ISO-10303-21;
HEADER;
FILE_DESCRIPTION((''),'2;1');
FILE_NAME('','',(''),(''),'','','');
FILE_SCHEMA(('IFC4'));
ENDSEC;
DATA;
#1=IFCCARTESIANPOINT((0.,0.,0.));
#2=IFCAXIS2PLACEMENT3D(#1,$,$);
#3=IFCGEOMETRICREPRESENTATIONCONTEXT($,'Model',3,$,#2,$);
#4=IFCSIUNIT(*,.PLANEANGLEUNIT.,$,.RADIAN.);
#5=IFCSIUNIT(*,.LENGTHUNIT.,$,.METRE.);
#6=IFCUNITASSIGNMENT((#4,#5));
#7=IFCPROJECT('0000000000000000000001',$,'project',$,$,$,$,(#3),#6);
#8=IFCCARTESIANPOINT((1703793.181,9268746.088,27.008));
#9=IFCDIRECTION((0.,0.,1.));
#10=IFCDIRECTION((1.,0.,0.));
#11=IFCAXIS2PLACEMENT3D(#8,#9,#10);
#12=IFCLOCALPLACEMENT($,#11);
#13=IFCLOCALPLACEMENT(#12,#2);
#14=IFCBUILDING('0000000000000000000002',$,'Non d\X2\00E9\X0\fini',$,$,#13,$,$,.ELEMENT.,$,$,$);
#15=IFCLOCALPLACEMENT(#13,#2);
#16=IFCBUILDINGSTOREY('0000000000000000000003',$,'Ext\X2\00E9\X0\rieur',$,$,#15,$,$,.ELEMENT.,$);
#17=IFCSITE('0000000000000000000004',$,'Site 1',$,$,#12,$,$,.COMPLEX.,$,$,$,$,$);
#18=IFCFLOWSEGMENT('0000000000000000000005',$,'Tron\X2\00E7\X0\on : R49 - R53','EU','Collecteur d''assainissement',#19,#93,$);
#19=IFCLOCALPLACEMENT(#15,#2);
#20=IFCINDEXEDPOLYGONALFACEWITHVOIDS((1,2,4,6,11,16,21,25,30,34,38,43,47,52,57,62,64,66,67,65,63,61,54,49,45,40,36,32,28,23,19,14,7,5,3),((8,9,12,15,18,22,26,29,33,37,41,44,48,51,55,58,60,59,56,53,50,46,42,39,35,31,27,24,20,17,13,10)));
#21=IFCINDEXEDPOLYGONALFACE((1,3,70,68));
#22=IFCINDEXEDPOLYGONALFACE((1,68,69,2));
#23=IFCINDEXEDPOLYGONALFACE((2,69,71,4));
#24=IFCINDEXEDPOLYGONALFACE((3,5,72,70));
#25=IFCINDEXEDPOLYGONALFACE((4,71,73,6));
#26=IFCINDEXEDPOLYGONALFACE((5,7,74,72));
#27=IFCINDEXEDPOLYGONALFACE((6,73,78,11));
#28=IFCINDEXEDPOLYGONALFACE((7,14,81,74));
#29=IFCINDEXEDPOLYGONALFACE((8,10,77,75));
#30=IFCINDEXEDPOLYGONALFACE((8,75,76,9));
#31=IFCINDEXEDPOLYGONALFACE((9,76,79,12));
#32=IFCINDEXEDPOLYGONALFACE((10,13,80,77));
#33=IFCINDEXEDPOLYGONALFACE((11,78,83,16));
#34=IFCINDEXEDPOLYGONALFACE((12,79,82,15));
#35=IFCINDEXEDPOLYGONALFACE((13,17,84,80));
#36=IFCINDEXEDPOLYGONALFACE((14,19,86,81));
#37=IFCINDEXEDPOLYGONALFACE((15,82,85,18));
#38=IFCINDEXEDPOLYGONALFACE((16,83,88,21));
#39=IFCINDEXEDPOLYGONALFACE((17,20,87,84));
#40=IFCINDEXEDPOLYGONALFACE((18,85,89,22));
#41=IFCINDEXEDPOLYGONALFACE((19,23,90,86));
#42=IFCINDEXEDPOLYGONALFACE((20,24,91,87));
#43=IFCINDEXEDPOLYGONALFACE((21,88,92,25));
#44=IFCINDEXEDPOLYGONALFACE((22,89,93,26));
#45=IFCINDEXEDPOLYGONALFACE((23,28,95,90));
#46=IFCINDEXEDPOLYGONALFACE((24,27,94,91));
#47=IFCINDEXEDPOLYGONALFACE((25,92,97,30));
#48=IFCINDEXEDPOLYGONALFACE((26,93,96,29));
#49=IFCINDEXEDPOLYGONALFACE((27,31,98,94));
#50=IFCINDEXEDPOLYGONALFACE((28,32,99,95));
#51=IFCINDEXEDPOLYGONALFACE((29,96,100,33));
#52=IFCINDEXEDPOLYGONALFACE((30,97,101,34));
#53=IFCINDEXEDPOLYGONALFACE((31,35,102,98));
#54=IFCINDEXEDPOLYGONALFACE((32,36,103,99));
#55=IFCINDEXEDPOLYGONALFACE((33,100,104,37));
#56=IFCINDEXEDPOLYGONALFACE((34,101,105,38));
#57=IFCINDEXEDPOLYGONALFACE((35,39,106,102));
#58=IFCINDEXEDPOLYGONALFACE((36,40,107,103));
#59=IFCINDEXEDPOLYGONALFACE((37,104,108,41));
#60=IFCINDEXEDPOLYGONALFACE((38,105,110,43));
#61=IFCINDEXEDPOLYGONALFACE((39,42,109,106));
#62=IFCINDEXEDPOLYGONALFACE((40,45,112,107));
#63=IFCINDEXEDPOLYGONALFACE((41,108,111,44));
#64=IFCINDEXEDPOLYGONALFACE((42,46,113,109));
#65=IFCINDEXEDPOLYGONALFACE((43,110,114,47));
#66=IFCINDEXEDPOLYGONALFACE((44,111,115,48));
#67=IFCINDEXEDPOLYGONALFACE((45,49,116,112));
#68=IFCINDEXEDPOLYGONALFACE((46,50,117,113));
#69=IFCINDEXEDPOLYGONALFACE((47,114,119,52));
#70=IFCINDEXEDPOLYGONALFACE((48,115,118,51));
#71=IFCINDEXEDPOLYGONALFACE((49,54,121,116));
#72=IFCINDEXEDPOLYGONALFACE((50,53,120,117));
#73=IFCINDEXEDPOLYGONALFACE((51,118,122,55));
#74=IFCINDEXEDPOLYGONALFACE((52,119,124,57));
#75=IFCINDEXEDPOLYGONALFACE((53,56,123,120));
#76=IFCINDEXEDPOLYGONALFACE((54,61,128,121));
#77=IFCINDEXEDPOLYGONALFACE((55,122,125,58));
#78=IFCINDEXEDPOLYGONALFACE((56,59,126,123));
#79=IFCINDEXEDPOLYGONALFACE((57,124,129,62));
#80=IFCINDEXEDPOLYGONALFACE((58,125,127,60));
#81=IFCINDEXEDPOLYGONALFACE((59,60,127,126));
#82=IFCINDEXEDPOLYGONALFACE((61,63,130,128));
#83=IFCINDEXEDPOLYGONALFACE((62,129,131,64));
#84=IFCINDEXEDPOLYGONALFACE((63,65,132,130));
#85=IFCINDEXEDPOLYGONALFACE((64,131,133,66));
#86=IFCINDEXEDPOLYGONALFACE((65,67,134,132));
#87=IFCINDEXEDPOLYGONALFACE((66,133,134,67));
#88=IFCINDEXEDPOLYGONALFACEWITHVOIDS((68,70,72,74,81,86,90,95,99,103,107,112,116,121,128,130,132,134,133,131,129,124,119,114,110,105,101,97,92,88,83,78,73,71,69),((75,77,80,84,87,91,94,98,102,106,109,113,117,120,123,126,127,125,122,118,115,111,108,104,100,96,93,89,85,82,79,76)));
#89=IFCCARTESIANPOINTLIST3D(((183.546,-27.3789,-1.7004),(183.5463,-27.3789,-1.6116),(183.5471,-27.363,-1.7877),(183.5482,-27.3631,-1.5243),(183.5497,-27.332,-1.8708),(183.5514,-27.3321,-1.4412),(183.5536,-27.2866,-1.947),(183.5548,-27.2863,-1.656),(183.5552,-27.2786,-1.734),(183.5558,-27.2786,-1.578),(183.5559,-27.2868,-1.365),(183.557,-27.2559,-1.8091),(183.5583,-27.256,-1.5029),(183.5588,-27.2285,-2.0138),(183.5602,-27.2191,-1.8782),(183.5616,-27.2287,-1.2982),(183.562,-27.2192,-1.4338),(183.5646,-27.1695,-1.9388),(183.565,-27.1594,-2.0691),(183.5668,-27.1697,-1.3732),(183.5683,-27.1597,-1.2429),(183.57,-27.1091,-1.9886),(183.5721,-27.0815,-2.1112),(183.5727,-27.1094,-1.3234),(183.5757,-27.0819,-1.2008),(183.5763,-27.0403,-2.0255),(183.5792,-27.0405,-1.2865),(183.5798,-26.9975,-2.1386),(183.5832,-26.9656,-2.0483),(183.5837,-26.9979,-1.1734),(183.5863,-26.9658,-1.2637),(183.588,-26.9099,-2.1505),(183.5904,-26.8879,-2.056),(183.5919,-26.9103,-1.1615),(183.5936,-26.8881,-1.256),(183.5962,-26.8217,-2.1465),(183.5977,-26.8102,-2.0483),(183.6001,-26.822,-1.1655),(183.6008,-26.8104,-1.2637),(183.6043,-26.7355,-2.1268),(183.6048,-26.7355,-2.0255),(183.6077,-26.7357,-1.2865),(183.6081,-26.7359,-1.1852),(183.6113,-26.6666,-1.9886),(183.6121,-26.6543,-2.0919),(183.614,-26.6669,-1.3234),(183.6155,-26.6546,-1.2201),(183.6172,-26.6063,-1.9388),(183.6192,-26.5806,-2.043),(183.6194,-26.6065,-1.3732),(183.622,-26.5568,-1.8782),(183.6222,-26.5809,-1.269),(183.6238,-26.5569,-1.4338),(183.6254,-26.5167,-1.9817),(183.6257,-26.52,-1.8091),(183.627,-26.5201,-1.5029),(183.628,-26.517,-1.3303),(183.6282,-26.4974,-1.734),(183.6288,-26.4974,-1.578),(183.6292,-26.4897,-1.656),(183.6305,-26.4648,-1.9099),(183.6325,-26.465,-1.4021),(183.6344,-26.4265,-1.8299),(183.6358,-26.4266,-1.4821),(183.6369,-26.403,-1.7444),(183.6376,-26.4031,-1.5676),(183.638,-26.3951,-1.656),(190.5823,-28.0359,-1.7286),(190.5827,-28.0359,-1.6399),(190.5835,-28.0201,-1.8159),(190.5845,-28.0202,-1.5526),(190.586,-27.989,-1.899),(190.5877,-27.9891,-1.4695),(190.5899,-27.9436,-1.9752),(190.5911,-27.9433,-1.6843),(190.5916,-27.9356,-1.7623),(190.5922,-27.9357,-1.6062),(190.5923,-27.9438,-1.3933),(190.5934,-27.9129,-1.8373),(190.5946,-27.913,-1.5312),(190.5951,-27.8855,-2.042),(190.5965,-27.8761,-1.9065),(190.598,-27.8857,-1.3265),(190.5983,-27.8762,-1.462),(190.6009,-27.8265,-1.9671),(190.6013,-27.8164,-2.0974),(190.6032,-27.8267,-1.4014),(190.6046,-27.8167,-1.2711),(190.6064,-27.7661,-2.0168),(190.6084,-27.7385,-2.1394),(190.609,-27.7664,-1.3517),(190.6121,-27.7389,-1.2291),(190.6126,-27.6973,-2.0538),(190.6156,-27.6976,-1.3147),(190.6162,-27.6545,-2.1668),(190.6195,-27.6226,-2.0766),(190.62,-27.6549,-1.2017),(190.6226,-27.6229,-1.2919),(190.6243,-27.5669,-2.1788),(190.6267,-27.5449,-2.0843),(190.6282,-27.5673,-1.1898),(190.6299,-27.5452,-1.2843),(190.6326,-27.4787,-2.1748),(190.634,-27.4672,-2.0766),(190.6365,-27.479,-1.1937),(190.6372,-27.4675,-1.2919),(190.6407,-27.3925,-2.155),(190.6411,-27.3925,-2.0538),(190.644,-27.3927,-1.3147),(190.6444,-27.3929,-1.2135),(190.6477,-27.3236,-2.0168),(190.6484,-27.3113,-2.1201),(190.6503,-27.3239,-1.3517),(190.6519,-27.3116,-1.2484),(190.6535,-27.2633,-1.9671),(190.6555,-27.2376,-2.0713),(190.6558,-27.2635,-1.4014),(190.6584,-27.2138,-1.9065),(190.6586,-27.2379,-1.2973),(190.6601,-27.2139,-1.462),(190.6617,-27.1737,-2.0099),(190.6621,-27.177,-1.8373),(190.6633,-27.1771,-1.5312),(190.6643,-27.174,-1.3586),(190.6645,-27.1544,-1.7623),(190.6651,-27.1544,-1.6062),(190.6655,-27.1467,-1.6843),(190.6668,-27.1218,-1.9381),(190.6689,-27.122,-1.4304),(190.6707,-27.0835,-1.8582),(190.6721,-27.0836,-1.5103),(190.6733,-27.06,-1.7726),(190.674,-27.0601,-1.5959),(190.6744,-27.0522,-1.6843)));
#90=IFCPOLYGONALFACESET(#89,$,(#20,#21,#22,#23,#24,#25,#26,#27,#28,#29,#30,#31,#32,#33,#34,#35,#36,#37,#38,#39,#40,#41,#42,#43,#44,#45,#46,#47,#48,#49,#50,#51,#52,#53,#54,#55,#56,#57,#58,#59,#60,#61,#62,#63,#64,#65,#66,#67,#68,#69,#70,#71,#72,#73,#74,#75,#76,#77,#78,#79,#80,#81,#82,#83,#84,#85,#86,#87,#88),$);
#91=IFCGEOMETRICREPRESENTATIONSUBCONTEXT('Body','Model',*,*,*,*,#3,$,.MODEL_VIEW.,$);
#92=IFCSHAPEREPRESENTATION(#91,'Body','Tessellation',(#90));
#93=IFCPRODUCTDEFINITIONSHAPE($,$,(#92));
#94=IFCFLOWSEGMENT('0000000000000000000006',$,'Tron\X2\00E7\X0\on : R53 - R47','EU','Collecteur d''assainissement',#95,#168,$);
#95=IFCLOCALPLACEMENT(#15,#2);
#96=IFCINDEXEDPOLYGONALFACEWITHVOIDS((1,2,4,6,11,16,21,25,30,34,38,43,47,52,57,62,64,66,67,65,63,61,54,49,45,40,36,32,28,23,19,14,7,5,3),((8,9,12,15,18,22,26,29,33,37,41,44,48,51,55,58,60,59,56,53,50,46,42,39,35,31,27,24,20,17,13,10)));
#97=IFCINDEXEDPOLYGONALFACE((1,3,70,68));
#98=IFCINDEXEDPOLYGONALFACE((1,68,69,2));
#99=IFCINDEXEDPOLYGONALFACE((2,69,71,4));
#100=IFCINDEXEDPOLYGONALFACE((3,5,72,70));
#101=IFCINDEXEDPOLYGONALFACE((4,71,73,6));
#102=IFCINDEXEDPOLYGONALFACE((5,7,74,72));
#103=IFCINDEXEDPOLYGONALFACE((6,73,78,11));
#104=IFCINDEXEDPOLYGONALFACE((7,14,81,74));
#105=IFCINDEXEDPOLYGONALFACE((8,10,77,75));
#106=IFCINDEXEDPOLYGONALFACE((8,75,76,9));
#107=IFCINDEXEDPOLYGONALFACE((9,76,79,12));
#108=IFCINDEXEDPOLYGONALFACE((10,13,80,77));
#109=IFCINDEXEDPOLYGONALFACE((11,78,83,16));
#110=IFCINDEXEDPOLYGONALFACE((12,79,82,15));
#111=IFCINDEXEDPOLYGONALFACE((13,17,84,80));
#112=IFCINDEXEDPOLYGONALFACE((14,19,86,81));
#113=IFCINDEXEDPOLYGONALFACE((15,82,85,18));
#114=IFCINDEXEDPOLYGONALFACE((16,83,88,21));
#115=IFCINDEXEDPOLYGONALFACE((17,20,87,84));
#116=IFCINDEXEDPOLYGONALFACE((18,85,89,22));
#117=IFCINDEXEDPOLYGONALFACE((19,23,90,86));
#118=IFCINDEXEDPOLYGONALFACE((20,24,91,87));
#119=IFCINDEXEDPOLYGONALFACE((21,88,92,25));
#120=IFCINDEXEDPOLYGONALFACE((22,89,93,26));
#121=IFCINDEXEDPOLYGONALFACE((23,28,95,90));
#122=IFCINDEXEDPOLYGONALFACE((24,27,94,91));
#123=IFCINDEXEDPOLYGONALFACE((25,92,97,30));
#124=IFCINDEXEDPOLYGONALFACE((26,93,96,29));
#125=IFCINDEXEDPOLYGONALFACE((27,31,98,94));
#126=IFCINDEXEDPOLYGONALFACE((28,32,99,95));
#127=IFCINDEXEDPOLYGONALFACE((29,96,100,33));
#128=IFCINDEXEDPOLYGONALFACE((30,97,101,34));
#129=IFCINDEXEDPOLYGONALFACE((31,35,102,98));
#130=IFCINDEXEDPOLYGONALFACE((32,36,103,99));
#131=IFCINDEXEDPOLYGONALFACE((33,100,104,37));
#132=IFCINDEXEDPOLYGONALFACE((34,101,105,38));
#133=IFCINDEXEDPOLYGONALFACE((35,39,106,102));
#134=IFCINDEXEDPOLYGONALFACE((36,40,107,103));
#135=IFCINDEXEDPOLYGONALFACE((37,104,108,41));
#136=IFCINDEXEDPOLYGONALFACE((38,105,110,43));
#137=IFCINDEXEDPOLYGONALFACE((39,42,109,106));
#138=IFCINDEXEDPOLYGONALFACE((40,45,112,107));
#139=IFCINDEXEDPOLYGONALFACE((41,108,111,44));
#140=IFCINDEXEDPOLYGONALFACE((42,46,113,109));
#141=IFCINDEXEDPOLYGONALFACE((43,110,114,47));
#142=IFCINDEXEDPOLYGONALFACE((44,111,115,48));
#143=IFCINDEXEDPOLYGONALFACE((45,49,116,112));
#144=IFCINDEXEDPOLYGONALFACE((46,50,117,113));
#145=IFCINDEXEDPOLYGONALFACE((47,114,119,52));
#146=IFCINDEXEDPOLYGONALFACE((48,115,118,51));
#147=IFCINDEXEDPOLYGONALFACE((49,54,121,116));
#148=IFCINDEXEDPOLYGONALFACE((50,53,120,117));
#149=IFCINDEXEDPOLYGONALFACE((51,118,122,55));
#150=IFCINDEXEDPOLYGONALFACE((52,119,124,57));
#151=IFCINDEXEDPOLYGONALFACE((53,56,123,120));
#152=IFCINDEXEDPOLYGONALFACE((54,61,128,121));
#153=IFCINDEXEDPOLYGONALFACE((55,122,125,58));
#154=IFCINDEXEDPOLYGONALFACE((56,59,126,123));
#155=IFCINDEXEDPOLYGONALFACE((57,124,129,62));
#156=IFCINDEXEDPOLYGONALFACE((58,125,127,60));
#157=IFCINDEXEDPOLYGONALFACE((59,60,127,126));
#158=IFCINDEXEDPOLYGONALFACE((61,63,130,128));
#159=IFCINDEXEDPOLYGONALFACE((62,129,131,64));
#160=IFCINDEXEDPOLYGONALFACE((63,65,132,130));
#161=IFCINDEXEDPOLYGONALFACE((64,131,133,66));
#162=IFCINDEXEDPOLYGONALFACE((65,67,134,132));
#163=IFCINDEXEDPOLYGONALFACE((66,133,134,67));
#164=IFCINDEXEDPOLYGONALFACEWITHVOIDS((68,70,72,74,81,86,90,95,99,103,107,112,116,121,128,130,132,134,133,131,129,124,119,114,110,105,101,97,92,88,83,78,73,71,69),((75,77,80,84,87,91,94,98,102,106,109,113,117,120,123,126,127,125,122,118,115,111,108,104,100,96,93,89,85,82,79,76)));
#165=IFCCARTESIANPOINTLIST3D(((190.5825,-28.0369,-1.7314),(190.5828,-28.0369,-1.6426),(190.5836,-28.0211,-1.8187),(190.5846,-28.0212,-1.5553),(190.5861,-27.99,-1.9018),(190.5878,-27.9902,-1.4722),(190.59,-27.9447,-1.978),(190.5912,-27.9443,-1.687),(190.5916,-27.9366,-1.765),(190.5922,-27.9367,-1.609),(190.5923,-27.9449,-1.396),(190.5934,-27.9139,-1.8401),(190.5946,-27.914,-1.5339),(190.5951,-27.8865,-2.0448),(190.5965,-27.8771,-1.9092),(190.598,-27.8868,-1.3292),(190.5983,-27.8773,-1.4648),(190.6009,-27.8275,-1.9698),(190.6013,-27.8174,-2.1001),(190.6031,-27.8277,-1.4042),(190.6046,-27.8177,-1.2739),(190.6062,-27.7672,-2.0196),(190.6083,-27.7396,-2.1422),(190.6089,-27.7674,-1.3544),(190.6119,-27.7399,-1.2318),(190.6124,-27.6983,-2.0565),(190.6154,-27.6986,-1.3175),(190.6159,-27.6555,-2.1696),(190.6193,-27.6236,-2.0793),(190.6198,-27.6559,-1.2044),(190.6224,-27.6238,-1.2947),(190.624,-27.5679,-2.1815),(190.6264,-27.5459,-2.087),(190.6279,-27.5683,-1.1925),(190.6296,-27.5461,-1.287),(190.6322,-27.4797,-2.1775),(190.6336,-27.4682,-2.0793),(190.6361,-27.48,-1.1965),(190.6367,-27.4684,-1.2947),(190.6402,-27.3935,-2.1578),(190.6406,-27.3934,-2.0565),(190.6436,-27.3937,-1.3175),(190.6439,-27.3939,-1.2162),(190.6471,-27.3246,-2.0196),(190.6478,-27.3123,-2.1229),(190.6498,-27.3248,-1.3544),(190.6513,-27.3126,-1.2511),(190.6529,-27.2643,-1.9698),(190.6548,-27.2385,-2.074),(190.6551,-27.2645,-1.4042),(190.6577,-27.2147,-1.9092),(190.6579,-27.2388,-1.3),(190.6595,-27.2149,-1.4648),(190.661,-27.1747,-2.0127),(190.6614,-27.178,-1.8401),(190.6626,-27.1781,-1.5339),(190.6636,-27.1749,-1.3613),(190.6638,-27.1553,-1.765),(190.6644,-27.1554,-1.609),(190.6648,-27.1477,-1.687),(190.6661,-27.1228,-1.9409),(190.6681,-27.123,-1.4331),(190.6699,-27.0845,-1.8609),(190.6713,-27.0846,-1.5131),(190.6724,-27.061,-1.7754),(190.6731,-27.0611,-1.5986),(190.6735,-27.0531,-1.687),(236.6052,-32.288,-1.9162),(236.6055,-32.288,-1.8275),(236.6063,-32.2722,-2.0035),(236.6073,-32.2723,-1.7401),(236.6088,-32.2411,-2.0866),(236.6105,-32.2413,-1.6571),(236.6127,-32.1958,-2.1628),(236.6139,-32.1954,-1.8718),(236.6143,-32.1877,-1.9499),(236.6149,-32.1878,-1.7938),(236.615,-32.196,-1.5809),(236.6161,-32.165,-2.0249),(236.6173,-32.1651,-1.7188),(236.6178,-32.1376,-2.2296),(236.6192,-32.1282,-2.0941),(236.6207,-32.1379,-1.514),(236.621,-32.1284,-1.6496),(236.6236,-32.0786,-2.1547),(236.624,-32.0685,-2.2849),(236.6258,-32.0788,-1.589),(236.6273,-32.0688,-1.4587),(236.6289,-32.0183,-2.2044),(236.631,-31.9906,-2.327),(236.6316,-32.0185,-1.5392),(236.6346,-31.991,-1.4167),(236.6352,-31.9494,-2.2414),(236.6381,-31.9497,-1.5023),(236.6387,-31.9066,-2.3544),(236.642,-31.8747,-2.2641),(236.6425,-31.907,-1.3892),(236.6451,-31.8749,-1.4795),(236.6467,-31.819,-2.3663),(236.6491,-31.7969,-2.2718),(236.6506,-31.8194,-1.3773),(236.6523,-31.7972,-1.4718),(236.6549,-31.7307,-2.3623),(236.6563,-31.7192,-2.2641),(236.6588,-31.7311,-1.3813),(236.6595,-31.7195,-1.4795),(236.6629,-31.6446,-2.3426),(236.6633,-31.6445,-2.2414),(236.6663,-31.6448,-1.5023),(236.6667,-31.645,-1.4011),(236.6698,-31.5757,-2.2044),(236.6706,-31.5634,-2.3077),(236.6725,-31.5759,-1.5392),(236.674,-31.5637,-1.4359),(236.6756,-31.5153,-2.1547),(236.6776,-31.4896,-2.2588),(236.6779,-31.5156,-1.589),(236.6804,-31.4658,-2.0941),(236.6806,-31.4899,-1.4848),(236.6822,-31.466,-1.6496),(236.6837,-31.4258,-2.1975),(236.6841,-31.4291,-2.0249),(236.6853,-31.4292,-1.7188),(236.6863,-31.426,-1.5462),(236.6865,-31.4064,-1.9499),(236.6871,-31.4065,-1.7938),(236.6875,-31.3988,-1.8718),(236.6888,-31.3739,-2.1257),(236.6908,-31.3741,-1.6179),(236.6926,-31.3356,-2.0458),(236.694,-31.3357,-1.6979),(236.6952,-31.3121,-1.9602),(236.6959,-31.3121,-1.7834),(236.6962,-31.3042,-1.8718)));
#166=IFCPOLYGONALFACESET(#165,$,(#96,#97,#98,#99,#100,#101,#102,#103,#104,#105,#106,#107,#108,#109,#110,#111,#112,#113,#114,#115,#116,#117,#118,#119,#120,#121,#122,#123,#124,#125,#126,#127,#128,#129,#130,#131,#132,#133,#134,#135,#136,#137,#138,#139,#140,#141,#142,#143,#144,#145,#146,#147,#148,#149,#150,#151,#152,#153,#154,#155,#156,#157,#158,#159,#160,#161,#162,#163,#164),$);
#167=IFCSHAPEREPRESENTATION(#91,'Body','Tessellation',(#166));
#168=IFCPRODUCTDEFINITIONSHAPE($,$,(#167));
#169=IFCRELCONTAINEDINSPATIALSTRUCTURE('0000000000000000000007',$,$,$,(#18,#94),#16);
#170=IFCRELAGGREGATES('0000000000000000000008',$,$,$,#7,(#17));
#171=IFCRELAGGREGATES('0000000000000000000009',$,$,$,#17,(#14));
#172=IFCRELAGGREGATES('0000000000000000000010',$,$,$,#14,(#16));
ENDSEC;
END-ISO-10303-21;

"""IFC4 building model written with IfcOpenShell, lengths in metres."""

from ifc_helpers import new_model, si_unit, frame, origin, origin_2d, place, context, subcontext, project, spatial, hollow_circle, extrude, element, save


model = new_model("IFC4")

# Units and contexts
model_context = context("Model", 3, world=origin())
body_context = subcontext(model_context, "Body", "Model", "MODEL_VIEW")
ifc_project = project(units=[si_unit("PLANEANGLEUNIT", "RADIAN"), si_unit("LENGTHUNIT", "METRE")], contexts=[model_context])

# Site, building, storey
site_placement = place(None, frame((1703793.181, 9268746.088, 27.008), z_axis=(0.0, 0.0, 1.0), x_axis=(1.0, 0.0, 0.0)))
site = spatial("IfcSite", under=ifc_project, at=site_placement, Name="Site 1", CompositionType="COMPLEX")
building_placement = place(site_placement, origin())
building = spatial("IfcBuilding", under=site, at=building_placement, Name="Non défini", CompositionType="ELEMENT")
storey_placement = place(building_placement, origin())
storey = spatial("IfcBuildingStorey", under=building, at=storey_placement, Name="Extérieur", CompositionType="ELEMENT")

# Flow segments
flow_segment_1_placement = place(storey_placement, origin())
element("IfcFlowSegment", 1, at=flow_segment_1_placement, inside=storey, Name="Tronçon : R49 - R53", Description="EU", ObjectType="Collecteur d'assainissement", context=body_context, shape_type="SweptSolid", body=[
    extrude(hollow_circle(Radius=0.495, WallThickness=0.095, at=origin_2d()), frame((183.592, -26.888, -1.656), z_axis=(0.996, -0.093, -0.004), x_axis=(0.093, 0.996, 0.0)), (0.0, 0.0, 1.0), 7.067),
])
flow_segment_2_placement = place(storey_placement, origin())
element("IfcFlowSegment", 2, at=flow_segment_2_placement, inside=storey, Name="Tronçon : R53 - R47", Description="EU", ObjectType="Collecteur d'assainissement", context=body_context, shape_type="SweptSolid", body=[
    extrude(hollow_circle(Radius=0.495, WallThickness=0.095, at=origin_2d()), frame((190.628, -27.546, -1.687), z_axis=(0.996, -0.092, -0.004), x_axis=(0.092, 0.996, 0.0)), (0.0, 0.0, 1.0), 46.219),
])

save(model, "model.ifc")
